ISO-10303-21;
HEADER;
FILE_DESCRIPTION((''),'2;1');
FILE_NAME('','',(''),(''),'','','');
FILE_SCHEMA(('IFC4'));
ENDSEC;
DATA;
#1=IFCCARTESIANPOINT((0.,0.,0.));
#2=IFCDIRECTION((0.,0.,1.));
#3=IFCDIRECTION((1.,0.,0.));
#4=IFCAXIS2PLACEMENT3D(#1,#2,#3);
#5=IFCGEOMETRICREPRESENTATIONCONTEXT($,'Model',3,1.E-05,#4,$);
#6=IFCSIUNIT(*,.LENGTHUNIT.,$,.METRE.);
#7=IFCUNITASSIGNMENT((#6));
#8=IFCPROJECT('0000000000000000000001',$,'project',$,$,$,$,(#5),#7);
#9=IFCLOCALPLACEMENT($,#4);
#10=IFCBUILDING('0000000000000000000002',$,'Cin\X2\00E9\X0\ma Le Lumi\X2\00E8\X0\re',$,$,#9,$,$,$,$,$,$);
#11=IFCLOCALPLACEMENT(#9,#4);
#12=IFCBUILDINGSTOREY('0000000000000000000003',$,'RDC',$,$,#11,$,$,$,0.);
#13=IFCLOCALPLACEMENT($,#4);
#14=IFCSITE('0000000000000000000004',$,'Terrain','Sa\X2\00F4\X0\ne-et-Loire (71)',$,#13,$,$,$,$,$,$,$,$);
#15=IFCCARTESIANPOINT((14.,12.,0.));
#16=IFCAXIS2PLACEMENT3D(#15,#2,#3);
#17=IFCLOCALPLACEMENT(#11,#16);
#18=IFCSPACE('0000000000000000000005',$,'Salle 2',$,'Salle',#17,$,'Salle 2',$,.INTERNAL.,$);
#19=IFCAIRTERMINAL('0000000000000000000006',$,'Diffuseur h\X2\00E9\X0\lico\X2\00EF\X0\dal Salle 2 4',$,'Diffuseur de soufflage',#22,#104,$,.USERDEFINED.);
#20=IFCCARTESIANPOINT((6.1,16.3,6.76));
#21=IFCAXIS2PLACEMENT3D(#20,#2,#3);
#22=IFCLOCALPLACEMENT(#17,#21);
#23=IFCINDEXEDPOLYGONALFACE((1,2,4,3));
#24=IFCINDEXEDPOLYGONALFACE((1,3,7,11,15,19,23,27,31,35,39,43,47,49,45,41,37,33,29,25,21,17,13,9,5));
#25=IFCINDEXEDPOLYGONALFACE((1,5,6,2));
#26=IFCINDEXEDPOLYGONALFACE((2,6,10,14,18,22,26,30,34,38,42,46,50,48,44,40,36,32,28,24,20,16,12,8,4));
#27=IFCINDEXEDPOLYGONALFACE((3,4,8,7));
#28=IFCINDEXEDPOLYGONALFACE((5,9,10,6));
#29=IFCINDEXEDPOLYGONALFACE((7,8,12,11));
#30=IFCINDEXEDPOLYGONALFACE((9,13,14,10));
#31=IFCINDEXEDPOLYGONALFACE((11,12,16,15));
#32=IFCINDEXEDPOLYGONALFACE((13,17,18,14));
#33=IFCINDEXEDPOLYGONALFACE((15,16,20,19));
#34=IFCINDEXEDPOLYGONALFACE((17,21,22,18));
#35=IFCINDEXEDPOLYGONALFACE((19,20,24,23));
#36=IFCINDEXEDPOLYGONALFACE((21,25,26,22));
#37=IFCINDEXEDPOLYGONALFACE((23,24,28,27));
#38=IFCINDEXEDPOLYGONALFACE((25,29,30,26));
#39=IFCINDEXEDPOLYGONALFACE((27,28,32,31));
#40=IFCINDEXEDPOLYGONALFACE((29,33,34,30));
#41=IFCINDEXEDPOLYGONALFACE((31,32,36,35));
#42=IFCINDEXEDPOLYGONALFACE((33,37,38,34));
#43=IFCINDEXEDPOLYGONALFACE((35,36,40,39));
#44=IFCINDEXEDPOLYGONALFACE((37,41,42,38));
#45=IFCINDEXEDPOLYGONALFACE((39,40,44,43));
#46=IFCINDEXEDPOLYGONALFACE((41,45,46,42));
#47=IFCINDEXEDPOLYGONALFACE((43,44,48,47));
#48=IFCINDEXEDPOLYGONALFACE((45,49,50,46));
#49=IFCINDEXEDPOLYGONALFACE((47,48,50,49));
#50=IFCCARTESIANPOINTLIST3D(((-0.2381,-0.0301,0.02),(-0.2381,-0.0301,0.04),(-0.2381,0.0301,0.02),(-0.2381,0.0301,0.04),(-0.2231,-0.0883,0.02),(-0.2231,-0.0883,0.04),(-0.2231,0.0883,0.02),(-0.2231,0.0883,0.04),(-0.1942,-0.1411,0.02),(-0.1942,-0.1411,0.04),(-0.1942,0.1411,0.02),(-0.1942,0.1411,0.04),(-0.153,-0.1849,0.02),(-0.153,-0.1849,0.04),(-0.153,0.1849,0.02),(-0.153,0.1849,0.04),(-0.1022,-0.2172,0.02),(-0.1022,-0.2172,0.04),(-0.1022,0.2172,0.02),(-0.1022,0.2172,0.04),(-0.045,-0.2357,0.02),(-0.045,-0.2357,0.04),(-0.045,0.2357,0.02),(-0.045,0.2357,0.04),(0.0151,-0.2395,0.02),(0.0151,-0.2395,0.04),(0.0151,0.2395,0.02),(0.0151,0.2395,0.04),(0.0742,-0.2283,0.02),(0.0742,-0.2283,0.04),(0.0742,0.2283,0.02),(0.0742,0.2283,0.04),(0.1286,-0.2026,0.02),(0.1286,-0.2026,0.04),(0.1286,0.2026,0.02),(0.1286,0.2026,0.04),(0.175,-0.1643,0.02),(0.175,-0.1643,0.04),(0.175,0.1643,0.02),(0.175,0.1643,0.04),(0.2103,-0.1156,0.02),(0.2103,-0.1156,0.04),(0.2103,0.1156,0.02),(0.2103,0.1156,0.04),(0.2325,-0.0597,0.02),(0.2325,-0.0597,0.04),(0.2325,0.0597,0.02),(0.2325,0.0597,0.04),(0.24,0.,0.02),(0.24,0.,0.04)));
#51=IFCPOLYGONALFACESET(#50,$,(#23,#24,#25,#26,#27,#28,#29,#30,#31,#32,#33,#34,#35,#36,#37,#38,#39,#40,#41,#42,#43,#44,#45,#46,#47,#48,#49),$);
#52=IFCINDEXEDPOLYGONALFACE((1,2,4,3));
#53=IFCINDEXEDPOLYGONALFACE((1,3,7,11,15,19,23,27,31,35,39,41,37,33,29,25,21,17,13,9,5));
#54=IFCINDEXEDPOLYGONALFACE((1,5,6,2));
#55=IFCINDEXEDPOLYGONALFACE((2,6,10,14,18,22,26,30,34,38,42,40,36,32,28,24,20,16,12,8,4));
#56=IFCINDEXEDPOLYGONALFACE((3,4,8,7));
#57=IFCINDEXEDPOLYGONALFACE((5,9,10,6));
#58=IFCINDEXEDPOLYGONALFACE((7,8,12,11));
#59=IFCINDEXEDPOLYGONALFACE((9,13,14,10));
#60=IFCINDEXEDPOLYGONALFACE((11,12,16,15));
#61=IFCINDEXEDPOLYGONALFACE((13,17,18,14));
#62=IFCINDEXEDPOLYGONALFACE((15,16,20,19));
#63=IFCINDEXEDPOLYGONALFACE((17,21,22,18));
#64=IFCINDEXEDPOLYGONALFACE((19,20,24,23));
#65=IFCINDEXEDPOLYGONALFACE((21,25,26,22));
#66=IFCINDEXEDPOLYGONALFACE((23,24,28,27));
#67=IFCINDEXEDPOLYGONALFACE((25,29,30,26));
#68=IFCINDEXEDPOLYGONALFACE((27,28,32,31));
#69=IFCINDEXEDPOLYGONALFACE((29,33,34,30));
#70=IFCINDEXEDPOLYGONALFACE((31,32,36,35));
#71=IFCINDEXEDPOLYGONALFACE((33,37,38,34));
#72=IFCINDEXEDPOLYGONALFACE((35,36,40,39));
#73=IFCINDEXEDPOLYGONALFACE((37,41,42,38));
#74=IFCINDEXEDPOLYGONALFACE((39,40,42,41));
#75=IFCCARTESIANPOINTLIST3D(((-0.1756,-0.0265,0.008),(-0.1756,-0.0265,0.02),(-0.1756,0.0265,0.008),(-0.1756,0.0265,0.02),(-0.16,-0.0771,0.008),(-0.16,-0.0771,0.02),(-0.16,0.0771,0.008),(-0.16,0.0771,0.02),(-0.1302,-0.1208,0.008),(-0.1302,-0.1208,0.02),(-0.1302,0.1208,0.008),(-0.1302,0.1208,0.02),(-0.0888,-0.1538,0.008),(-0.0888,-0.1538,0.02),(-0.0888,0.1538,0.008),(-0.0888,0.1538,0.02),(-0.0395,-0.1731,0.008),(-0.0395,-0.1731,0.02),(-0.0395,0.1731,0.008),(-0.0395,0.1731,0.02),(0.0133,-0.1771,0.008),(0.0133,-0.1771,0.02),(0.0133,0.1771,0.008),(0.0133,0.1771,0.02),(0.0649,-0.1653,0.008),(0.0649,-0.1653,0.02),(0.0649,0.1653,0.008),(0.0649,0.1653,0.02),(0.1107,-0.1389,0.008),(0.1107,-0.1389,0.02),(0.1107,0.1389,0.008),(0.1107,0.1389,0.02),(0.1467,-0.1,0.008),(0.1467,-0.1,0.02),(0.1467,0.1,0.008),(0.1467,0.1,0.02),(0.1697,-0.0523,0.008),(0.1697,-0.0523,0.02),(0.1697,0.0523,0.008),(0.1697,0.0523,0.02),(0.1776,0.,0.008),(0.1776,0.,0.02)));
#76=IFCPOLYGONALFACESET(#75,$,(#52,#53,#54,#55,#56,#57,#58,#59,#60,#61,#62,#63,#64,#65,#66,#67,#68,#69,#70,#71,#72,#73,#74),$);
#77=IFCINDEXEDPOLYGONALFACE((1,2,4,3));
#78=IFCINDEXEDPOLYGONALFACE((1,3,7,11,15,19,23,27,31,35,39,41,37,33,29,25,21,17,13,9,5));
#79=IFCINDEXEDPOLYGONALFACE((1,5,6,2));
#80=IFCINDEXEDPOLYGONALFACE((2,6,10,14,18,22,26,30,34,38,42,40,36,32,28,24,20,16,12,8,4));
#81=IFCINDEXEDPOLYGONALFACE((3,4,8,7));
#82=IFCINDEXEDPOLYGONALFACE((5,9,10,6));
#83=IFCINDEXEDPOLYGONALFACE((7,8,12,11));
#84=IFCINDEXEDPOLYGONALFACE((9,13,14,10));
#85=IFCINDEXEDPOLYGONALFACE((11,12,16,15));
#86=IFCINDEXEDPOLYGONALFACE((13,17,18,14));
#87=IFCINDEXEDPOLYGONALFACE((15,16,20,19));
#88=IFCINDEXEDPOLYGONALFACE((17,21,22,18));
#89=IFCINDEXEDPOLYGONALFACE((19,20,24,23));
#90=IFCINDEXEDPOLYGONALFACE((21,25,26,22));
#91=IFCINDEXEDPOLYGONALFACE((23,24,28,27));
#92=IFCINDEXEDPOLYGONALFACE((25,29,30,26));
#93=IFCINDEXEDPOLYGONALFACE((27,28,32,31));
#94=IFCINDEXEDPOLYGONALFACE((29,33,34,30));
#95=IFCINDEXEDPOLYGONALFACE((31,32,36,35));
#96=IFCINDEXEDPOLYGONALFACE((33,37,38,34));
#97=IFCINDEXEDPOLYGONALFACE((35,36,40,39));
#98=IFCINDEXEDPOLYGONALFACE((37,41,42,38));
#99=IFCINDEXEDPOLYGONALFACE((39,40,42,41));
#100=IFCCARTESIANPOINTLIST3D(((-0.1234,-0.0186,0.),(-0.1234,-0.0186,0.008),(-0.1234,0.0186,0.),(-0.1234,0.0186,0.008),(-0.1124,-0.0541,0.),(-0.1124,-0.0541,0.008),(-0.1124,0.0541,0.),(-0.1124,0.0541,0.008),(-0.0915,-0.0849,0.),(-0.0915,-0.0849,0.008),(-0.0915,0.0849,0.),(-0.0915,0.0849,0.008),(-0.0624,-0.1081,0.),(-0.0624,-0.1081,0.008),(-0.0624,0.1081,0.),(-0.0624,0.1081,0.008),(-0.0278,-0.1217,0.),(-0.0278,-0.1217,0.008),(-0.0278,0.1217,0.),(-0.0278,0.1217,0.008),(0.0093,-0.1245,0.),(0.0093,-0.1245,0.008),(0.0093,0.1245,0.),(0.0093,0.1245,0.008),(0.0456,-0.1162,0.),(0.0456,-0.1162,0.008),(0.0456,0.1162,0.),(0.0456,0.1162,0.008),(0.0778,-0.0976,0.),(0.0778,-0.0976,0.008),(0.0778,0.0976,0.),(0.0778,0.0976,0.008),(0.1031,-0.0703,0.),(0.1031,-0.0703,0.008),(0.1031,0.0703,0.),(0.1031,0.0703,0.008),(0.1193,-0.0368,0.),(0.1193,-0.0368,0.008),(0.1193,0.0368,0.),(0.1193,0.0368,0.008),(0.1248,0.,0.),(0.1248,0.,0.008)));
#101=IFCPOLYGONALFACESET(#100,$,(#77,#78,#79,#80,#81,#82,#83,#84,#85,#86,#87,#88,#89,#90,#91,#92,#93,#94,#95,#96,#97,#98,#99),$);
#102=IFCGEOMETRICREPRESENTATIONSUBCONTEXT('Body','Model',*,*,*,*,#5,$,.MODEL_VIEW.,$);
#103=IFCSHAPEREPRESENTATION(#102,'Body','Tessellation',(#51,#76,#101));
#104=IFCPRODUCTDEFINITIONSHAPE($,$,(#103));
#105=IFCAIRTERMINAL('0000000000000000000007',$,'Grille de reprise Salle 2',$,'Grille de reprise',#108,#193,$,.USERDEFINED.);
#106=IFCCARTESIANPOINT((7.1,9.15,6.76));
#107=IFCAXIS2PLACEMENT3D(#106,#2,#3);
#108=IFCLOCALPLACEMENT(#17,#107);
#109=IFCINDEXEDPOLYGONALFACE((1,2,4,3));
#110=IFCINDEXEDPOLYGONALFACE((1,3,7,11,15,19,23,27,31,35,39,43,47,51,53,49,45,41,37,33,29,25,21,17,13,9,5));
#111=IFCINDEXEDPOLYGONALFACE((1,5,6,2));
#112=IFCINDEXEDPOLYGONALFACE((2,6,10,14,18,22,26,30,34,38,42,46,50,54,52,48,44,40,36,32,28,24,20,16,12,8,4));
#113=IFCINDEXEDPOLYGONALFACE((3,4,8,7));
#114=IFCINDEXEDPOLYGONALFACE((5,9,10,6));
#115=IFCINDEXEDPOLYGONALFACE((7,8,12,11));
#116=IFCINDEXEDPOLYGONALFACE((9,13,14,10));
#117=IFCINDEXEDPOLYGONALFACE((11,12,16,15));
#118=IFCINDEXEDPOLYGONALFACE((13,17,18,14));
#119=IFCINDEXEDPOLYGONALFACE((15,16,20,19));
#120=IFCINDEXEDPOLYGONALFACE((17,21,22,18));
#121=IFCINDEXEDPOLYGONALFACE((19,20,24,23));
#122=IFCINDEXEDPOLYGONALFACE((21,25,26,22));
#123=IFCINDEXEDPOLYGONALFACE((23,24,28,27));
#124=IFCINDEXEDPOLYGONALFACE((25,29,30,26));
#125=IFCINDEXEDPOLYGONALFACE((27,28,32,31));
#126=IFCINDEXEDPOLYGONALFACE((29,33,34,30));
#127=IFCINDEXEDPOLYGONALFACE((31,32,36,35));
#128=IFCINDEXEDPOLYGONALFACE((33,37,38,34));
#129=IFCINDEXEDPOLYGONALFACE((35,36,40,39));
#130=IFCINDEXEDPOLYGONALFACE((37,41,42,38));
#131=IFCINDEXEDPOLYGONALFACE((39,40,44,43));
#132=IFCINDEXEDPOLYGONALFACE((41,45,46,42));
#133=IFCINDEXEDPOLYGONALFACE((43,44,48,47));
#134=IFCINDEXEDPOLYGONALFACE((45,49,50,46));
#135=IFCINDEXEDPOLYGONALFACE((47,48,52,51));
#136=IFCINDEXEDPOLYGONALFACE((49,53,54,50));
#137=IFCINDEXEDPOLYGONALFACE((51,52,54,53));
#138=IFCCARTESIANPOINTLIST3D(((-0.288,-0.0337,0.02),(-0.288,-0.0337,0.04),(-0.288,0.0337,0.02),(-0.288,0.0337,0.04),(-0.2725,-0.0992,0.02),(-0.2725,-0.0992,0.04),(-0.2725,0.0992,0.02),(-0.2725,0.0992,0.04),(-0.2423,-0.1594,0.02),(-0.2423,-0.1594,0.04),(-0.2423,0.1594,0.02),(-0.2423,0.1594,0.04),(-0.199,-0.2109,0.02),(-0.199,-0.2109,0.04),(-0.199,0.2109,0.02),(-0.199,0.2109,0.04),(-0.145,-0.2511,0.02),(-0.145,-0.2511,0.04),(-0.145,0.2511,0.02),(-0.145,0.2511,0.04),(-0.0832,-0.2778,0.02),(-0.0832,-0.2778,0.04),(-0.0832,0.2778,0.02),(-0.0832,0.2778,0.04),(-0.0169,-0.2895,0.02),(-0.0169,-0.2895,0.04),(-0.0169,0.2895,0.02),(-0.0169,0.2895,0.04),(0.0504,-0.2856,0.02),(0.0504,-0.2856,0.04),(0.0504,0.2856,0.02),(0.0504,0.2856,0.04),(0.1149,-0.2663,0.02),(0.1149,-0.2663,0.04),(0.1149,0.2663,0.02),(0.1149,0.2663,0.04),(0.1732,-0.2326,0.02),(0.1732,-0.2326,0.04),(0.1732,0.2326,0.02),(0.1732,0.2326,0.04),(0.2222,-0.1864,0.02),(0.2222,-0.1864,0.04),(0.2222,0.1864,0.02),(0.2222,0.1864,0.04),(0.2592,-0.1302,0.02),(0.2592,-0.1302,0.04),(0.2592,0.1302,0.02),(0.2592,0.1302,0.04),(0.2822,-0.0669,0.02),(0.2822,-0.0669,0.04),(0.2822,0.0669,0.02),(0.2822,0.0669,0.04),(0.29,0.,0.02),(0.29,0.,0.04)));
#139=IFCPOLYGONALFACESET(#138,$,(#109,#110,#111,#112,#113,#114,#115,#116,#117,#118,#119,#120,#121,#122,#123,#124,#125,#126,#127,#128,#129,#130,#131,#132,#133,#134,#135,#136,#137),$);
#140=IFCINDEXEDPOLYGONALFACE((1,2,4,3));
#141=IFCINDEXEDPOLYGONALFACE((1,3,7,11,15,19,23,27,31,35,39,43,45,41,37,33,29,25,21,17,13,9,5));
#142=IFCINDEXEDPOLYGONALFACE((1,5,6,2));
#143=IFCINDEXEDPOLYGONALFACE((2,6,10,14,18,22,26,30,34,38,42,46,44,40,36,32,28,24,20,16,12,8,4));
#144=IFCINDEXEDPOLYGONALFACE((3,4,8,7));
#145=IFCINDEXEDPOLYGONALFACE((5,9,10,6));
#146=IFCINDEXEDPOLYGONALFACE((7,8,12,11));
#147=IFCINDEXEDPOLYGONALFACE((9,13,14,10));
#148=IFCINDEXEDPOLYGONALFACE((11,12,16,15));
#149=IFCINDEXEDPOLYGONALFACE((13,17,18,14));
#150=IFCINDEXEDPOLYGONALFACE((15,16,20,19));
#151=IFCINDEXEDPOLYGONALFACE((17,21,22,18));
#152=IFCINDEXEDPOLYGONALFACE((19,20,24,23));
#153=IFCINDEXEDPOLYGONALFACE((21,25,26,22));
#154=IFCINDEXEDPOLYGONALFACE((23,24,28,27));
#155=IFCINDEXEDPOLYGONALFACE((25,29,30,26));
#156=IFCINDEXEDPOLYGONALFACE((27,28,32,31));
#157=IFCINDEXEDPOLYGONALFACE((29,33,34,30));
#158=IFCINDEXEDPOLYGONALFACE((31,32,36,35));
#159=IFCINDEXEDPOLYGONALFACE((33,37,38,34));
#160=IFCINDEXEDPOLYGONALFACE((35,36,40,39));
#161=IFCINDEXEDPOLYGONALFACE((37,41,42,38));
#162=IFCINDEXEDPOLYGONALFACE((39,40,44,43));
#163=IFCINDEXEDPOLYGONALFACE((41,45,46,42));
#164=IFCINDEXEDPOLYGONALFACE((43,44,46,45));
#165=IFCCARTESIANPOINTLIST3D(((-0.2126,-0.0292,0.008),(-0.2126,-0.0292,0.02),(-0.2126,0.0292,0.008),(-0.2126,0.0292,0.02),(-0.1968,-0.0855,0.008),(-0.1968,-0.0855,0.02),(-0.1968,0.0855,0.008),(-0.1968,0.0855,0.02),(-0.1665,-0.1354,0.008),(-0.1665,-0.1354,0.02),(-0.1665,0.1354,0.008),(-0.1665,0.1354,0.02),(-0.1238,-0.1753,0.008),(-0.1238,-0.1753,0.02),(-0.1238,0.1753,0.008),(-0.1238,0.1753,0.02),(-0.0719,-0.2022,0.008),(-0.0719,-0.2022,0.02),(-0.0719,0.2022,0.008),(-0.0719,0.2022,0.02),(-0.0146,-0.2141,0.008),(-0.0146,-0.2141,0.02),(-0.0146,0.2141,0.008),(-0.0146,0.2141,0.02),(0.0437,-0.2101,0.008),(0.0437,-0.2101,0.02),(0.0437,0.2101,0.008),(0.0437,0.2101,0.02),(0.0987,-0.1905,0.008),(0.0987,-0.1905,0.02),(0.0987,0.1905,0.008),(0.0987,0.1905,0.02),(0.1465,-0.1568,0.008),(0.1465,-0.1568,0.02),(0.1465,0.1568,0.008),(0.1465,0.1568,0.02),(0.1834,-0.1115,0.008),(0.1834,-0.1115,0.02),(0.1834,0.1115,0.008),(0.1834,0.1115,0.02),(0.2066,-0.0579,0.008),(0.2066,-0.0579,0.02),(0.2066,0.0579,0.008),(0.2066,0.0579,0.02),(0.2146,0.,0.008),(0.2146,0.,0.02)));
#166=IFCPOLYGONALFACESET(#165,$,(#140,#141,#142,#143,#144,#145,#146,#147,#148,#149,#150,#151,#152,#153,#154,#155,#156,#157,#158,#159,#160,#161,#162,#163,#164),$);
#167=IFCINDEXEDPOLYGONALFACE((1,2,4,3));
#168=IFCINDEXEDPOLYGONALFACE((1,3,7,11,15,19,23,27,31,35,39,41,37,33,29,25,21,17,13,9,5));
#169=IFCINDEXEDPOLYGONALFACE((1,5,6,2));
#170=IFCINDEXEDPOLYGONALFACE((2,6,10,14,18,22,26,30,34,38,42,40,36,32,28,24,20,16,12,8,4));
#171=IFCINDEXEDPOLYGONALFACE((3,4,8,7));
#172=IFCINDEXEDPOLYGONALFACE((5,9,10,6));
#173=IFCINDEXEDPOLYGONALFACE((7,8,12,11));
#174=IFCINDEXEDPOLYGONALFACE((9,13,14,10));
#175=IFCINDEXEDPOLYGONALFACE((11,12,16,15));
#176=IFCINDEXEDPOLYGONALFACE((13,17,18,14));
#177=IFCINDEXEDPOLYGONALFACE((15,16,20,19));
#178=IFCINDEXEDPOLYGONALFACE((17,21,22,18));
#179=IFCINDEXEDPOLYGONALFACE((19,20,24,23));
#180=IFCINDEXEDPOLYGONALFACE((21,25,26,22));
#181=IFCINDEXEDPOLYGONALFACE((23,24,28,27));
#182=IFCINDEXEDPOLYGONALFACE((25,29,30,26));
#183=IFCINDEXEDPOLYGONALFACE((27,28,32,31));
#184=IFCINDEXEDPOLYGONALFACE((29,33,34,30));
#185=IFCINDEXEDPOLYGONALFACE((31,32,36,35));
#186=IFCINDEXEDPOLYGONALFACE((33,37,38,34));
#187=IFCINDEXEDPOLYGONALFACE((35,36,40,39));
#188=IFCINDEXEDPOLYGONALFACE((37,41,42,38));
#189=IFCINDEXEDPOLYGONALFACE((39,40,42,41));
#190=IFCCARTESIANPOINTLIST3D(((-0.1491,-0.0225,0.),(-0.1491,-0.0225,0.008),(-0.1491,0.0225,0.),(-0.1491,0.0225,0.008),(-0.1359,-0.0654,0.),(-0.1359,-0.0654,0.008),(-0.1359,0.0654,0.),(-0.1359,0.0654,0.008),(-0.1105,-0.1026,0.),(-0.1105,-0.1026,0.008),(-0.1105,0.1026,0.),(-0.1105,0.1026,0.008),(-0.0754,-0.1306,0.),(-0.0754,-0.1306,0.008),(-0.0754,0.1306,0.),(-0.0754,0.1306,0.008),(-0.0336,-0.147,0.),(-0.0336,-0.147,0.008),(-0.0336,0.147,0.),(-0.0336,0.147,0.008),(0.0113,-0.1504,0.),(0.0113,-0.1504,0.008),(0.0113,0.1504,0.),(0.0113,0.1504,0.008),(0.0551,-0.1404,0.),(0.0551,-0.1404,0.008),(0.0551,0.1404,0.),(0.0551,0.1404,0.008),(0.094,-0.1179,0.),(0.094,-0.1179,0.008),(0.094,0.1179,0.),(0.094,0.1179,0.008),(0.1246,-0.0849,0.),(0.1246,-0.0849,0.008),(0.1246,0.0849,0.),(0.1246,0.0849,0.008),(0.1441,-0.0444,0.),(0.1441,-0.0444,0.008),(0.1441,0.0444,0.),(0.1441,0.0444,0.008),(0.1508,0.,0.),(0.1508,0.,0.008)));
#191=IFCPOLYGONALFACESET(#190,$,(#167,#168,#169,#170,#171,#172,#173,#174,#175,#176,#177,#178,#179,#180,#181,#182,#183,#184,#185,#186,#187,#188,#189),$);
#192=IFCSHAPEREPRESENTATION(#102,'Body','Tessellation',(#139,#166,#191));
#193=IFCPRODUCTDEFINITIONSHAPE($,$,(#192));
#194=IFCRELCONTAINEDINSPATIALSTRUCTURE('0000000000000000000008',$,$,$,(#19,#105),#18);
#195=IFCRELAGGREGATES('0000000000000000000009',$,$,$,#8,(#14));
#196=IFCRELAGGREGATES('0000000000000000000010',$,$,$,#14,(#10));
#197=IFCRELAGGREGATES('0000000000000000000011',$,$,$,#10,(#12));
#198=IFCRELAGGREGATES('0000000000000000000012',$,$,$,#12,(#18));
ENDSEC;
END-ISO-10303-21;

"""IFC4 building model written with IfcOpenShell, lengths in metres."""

from ifc_helpers import new_model, si_unit, frame, origin_with_axes, place, context, subcontext, project, spatial, circle, extrude, element, save


model = new_model("IFC4")

# Units and contexts
model_context = context("Model", 3, precision=1e-05, world=origin_with_axes())
body_context = subcontext(model_context, "Body", "Model", "MODEL_VIEW")
ifc_project = project(units=[si_unit("LENGTHUNIT", "METRE")], contexts=[model_context])

# Site, building, storey
site_placement = place(None, origin_with_axes())
site = spatial("IfcSite", under=ifc_project, at=site_placement, Name="Terrain", Description="Saône-et-Loire (71)")
building_placement = place(None, origin_with_axes())
building = spatial("IfcBuilding", under=site, at=building_placement, Name="Cinéma Le Lumière")
storey_placement = place(building_placement, origin_with_axes())
storey = spatial("IfcBuildingStorey", under=building, at=storey_placement, Name="RDC", Elevation=0.0)

# Shared definitions
space_1_placement = place(storey_placement, frame((14.0, 12.0, 0.0), z_axis=(0.0, 0.0, 1.0), x_axis=(1.0, 0.0, 0.0)))
space_1 = spatial("IfcSpace", under=storey, at=space_1_placement, Name="Salle 2", ObjectType="Salle", LongName="Salle 2", PredefinedType="INTERNAL")

# Air terminals
for number, where, z_axis, x_axis, name in (
    (1, (6.1, 16.3, 6.76), (0.0, 0.0, 1.0), (1.0, 0.0, 0.0), "Diffuseur hélicoïdal Salle 2 4"),
):
    element("IfcAirTerminal", number, at=place(space_1_placement, frame(where, z_axis=z_axis, x_axis=x_axis)), inside=space_1, Name=name, ObjectType="Diffuseur de soufflage", PredefinedType="USERDEFINED", context=body_context, shape_type="SweptSolid", body=[
        extrude(circle(Radius=0.24), frame((0.0, 0.0, 0.02), z_axis=(0.0, 0.0, 1.0), x_axis=(1.0, 0.0, 0.0)), (0.0, 0.0, 1.0), 0.02),
        extrude(circle(Radius=0.1776), frame((0.0, 0.0, 0.008), z_axis=(0.0, 0.0, 1.0), x_axis=(1.0, 0.0, 0.0)), (0.0, 0.0, 1.0), 0.012),
        extrude(circle(Radius=0.1248), origin_with_axes(), (0.0, 0.0, 1.0), 0.008),
    ])
air_terminal_1_placement = place(space_1_placement, frame((7.1, 9.15, 6.76), z_axis=(0.0, 0.0, 1.0), x_axis=(1.0, 0.0, 0.0)))
element("IfcAirTerminal", 2, at=air_terminal_1_placement, inside=space_1, Name="Grille de reprise Salle 2", ObjectType="Grille de reprise", PredefinedType="USERDEFINED", context=body_context, shape_type="SweptSolid", body=[
    extrude(circle(Radius=0.29), frame((0.0, 0.0, 0.02), z_axis=(0.0, 0.0, 1.0), x_axis=(1.0, 0.0, 0.0)), (0.0, 0.0, 1.0), 0.02),
    extrude(circle(Radius=0.2146), frame((0.0, 0.0, 0.008), z_axis=(0.0, 0.0, 1.0), x_axis=(1.0, 0.0, 0.0)), (0.0, 0.0, 1.0), 0.012),
    extrude(circle(Radius=0.1508), origin_with_axes(), (0.0, 0.0, 1.0), 0.008),
])

save(model, "model.ifc")
